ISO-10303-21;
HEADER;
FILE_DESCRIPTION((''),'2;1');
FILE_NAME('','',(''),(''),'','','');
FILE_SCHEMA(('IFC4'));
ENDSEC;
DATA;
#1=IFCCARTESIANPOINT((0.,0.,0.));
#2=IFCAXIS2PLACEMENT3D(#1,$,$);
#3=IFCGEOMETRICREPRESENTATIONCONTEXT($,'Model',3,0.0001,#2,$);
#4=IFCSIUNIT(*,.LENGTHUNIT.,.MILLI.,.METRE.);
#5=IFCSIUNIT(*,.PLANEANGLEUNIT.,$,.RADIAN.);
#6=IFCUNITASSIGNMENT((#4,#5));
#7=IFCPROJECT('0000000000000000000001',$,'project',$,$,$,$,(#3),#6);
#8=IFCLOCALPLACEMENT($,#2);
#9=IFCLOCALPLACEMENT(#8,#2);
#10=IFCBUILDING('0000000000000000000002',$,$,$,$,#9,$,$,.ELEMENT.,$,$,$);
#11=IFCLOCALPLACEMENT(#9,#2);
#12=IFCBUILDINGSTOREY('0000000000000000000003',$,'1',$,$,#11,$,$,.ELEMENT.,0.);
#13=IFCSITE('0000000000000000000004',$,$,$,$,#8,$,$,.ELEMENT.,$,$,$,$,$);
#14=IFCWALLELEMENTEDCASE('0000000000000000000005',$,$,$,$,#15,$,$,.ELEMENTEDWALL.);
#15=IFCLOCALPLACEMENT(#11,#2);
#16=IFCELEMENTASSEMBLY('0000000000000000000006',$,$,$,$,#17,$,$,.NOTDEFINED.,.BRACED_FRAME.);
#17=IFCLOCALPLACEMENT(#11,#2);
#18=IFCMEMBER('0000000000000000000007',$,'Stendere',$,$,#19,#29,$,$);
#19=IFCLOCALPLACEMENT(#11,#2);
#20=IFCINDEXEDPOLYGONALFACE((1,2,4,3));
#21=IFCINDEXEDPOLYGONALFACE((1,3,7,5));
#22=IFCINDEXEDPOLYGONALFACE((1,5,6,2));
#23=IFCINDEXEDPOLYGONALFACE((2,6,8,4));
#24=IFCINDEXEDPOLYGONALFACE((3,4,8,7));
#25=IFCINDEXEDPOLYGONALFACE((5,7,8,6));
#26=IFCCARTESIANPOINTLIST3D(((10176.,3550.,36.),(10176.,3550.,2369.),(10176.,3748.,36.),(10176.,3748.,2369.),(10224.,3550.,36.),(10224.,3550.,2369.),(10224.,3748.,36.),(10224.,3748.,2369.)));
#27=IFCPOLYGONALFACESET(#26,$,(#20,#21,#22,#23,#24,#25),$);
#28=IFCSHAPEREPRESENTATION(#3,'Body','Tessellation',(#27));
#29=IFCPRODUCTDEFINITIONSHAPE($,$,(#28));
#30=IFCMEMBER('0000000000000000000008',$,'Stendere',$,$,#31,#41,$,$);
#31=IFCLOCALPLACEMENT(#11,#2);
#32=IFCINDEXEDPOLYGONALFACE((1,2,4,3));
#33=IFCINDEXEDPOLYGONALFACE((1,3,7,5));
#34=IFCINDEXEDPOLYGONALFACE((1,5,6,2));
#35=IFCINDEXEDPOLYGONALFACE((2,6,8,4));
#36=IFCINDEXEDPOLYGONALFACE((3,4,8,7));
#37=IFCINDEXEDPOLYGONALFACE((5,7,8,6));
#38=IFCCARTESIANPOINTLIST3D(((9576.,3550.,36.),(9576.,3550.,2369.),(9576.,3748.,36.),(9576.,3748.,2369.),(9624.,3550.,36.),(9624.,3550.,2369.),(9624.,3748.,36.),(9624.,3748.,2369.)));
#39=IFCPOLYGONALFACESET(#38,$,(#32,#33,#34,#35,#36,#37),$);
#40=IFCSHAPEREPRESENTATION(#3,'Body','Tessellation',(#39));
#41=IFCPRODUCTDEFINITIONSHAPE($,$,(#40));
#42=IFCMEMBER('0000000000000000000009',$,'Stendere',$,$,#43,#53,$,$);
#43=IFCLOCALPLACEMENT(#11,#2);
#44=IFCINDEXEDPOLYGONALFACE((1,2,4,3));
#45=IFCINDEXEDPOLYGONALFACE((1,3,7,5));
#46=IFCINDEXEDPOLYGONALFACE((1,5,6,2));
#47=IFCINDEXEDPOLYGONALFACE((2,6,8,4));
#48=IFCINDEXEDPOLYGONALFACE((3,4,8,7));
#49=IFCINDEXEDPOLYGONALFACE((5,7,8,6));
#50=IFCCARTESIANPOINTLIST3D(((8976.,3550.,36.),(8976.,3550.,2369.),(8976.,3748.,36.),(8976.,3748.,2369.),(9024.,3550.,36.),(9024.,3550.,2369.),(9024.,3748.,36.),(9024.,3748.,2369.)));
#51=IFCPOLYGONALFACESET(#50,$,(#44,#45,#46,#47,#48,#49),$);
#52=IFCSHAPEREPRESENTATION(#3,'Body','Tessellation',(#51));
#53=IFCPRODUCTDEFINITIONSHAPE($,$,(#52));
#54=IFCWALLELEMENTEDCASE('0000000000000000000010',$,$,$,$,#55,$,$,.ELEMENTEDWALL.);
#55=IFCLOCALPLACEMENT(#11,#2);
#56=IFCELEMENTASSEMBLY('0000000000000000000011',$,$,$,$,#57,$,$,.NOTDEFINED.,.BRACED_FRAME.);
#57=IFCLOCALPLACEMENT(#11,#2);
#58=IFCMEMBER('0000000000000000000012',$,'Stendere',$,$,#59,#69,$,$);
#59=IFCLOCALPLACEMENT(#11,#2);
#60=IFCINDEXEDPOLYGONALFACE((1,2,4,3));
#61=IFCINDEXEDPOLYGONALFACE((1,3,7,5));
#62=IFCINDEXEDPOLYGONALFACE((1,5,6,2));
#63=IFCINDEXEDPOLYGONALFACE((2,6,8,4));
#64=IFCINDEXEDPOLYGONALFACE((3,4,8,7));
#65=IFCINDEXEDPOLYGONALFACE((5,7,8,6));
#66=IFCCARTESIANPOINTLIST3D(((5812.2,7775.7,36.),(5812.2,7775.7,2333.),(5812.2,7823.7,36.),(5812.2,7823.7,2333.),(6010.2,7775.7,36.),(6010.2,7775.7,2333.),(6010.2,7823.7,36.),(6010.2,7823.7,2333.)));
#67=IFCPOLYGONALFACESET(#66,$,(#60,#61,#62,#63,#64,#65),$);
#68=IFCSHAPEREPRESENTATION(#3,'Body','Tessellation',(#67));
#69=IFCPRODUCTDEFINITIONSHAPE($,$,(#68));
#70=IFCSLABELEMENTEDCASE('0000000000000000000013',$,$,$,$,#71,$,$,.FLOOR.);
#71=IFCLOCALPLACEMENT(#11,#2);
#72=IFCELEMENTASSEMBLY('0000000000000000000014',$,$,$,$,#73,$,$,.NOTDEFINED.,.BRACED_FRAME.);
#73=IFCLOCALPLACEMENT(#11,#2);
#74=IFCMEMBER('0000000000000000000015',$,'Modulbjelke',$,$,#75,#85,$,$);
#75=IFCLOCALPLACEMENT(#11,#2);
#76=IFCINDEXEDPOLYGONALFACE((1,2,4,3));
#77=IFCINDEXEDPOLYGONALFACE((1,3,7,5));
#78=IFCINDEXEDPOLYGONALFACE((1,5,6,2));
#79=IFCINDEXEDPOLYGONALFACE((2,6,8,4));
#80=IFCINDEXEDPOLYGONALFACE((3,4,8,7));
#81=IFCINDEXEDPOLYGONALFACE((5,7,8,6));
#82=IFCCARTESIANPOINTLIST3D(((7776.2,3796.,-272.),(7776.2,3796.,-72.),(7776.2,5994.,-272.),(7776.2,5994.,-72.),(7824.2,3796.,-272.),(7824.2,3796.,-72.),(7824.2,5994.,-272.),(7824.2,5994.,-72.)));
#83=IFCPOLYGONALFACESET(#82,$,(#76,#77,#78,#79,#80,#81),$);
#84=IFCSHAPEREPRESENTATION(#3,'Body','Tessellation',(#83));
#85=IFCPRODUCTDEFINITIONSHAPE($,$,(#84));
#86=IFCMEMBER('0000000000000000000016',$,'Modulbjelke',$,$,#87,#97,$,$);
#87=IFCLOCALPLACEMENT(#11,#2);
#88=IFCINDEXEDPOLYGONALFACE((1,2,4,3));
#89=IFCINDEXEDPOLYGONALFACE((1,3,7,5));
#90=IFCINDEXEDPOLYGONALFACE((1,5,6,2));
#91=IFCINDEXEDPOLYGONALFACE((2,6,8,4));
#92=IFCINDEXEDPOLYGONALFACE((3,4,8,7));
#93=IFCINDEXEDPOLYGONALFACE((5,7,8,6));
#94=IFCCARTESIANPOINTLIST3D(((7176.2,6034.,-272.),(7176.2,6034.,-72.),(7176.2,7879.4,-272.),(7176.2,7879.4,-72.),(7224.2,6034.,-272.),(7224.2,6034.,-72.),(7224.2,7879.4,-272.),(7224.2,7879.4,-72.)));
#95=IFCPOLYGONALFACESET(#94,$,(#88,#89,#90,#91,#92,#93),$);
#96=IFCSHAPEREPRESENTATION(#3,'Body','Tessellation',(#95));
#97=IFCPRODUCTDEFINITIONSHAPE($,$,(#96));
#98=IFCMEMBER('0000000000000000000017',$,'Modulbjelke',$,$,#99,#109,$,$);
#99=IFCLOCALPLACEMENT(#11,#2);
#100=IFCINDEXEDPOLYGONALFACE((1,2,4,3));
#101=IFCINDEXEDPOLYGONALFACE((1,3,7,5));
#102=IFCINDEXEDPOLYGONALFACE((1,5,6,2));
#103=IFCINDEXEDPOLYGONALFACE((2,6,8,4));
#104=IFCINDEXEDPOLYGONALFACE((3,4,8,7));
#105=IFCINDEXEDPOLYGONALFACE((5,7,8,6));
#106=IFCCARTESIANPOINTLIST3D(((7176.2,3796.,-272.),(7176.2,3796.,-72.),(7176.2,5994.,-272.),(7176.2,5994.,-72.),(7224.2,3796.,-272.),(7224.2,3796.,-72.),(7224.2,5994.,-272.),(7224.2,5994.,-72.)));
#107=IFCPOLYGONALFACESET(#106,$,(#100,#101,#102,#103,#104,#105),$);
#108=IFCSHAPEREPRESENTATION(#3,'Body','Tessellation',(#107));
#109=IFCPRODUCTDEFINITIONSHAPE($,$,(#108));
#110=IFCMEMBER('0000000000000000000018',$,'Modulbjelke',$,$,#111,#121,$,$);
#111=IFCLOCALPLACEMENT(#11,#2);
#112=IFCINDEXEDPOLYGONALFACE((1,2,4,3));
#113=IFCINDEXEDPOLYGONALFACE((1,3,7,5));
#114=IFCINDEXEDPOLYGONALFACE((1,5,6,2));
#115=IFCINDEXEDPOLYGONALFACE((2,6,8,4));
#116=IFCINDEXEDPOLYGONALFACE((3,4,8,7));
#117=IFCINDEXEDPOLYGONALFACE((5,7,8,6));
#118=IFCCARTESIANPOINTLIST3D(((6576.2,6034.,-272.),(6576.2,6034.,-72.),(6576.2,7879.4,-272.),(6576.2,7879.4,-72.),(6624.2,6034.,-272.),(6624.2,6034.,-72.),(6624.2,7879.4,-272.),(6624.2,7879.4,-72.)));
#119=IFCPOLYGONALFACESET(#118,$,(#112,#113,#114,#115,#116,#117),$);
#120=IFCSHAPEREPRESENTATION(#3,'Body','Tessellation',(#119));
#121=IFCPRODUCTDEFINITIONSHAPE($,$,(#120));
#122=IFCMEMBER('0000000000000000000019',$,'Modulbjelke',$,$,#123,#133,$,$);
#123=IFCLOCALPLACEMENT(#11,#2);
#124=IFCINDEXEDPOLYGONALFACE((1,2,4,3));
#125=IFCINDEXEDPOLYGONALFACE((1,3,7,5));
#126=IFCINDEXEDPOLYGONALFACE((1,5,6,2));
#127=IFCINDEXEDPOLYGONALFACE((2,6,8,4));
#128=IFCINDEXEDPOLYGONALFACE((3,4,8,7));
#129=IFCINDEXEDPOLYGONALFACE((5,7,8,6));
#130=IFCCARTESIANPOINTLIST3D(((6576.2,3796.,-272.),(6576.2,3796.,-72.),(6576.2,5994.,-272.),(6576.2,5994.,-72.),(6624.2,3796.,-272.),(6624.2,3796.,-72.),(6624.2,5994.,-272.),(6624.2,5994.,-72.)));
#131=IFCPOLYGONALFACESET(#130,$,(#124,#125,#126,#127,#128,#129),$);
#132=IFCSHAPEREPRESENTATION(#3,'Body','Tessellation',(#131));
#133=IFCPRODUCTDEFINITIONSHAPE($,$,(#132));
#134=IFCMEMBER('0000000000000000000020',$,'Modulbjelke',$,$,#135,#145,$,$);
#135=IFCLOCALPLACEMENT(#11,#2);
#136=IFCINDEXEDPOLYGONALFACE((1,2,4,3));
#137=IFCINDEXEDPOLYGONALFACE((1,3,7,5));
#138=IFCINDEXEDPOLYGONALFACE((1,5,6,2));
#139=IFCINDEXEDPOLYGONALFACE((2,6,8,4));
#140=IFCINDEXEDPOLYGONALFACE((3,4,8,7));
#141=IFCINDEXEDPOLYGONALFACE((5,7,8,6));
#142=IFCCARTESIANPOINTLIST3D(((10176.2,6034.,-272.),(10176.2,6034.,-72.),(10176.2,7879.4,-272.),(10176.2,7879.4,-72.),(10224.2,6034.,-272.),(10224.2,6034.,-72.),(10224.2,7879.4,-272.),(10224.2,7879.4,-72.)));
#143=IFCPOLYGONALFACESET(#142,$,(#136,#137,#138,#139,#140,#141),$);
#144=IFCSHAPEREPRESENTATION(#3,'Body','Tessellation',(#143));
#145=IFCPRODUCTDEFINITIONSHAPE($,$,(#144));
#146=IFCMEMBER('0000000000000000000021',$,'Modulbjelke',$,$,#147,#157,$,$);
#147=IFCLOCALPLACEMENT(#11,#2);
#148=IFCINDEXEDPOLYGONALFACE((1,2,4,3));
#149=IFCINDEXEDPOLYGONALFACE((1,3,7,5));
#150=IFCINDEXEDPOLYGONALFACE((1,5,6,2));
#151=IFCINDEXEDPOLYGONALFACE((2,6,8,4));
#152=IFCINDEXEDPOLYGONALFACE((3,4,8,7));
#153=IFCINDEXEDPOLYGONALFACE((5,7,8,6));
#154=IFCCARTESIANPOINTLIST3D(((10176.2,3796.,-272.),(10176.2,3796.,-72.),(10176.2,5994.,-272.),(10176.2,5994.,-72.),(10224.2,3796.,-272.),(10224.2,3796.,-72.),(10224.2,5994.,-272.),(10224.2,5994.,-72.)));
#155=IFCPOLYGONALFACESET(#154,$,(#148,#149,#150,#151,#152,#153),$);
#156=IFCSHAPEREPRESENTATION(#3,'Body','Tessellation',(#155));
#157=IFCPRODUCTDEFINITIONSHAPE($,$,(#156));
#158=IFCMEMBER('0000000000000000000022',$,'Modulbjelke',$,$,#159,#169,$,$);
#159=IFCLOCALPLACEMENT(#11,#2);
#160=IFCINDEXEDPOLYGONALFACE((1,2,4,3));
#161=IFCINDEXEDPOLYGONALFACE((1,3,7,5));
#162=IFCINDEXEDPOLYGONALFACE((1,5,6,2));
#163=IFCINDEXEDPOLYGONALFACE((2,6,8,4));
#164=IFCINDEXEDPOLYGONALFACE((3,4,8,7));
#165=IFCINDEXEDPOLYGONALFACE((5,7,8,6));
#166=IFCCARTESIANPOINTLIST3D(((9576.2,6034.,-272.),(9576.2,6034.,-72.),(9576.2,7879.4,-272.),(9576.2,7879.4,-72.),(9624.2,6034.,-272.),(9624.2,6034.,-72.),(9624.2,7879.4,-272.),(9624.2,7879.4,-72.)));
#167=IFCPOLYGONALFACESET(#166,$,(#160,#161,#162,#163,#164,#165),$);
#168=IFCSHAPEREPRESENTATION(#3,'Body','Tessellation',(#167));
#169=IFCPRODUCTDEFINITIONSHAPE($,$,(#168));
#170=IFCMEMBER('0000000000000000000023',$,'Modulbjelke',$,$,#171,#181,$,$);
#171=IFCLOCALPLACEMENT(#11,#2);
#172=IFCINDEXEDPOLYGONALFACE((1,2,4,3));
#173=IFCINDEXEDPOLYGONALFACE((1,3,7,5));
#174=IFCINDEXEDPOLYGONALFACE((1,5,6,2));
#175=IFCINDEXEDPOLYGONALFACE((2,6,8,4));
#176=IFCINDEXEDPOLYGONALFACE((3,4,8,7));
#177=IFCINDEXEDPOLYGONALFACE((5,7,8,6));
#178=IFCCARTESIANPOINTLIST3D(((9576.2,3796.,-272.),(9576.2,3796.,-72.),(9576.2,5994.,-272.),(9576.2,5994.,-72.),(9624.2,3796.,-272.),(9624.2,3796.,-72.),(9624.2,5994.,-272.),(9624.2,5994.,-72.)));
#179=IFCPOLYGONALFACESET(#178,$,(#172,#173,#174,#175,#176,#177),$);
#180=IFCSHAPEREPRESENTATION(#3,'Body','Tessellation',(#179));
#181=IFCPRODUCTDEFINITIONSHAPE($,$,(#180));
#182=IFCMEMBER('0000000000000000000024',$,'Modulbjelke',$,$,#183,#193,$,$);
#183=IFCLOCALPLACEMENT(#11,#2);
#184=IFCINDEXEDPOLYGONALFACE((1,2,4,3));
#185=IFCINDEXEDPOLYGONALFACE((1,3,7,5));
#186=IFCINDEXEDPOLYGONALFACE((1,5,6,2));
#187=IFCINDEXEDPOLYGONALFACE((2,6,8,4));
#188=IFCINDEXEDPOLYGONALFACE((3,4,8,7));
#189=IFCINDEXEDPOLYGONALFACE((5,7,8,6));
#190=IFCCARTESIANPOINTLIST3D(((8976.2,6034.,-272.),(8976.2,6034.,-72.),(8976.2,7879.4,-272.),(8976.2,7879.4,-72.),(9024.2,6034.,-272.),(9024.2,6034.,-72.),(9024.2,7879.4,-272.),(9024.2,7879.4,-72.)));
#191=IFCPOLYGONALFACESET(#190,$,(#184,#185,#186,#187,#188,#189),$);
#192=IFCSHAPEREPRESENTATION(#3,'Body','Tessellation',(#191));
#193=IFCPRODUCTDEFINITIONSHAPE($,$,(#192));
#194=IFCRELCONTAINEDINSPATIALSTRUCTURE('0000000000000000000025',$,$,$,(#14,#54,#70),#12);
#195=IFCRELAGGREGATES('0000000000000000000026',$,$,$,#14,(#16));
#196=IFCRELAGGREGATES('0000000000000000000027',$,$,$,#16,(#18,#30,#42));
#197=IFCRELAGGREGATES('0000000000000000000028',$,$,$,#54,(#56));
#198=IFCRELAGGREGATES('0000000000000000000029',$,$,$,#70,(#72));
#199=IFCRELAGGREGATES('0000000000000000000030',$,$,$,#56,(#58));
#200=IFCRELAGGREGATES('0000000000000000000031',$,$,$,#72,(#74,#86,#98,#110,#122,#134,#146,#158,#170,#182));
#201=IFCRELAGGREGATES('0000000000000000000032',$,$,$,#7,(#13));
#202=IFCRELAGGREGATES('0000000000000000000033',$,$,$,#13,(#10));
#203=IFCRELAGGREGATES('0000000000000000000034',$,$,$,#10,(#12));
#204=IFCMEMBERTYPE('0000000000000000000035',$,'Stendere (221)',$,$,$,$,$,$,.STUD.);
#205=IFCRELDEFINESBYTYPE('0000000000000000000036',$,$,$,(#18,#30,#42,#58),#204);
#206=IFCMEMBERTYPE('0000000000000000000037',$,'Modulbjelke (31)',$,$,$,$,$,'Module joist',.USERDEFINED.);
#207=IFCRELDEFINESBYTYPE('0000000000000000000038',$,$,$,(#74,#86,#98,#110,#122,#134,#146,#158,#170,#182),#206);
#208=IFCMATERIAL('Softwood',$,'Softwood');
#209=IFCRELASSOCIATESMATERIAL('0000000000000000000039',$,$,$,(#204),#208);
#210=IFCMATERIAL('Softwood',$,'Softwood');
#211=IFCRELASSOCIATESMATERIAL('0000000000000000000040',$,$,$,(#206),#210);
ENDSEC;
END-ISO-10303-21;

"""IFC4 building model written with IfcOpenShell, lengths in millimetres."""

from ifc_helpers import new_model, si_unit, frame, origin, place, context, project, spatial, rectangle, extrude, clip, halfspace, material, material_profile, profile_set, type_object, element, aggregate, save


model = new_model("IFC4")

# Units and contexts
model_context = context("Model", 3, precision=0.0001, world=origin())
ifc_project = project(units=[si_unit("LENGTHUNIT", "METRE", prefix="MILLI"), si_unit("PLANEANGLEUNIT", "RADIAN")], contexts=[model_context])

# Site, building, storey
site_placement = place(None, origin())
site = spatial("IfcSite", under=ifc_project, at=site_placement, CompositionType="ELEMENT")
building_placement = place(site_placement, origin())
building = spatial("IfcBuilding", under=site, at=building_placement, CompositionType="ELEMENT")
storey_placement = place(building_placement, origin())
storey = spatial("IfcBuildingStorey", under=building, at=storey_placement, Name="1", CompositionType="ELEMENT", Elevation=0.0)

# Wall, element assembly, members
wall_1_placement = place(storey_placement, frame((6576.0, 3748.0, 0.0), z_axis=(0.0, -1.0, 0.0)))
wall_1 = element("IfcWallElementedCase", 1, at=wall_1_placement, inside=storey, PredefinedType="ELEMENTEDWALL")
assembly_1_placement = place(wall_1_placement, origin())
assembly_1 = element("IfcElementAssembly", 2, at=assembly_1_placement, AssemblyPlace="NOTDEFINED", PredefinedType="BRACED_FRAME")
aggregate(wall_1, [assembly_1])
ifc_material_1 = material(Name="Softwood", Category="Softwood")
ifc_material_profile_1 = material_profile(ifc_material_1, rectangle(XDim=48.0, YDim=198.0), Name="Stendere (221)")
ifc_profile_set_1 = profile_set([ifc_material_profile_1])
member_type_1 = type_object("IfcMemberType", Name="Stendere (221)", PredefinedType="STUD", material=ifc_profile_set_1)
member_1_placement = place(assembly_1_placement, frame((3624.0, 36.0, 0.0), z_axis=(0.0, 1.0, 0.0), x_axis=(-1.0, 0.0, 0.0)))
member_1 = element("IfcMember", 3, at=member_1_placement, type_object=member_type_1, Name="Stendere", context=model_context, shape_type="SweptSolid", body=[
    extrude(rectangle(XDim=48.0, YDim=198.0), frame((0.0, 99.0, 0.0)), (0.0, 0.0, 1.0), 2333.0),
])
member_2_placement = place(assembly_1_placement, frame((3024.0, 36.0, 0.0), z_axis=(0.0, 1.0, 0.0), x_axis=(-1.0, 0.0, 0.0)))
member_2 = element("IfcMember", 4, at=member_2_placement, type_object=member_type_1, Name="Stendere", context=model_context, shape_type="SweptSolid", body=[
    extrude(rectangle(XDim=48.0, YDim=198.0), frame((0.0, 99.0, 0.0)), (0.0, 0.0, 1.0), 2333.0),
])
member_3_placement = place(assembly_1_placement, frame((2424.0, 36.0, 0.0), z_axis=(0.0, 1.0, 0.0), x_axis=(-1.0, 0.0, 0.0)))
member_3 = element("IfcMember", 5, at=member_3_placement, type_object=member_type_1, Name="Stendere", context=model_context, shape_type="Clipping", body=[
    clip(extrude(rectangle(XDim=48.0, YDim=198.0), frame((0.0, 99.0, 0.0)), (0.0, 0.0, 1.0), 2333.0), halfspace(frame((0.0, 99.0, 0.0)), True)),
])
aggregate(assembly_1, [member_1, member_2, member_3])

# Wall, element assembly, member
wall_2_placement = place(storey_placement, frame((6010.2, 8138.7, 0.0), z_axis=(-1.0, 0.0, 0.0), x_axis=(0.0, -1.0, 0.0)))
wall_2 = element("IfcWallElementedCase", 6, at=wall_2_placement, inside=storey, PredefinedType="ELEMENTEDWALL")
assembly_2_placement = place(wall_2_placement, origin())
assembly_2 = element("IfcElementAssembly", 7, at=assembly_2_placement, AssemblyPlace="NOTDEFINED", PredefinedType="BRACED_FRAME")
aggregate(wall_2, [assembly_2])
member_4_placement = place(assembly_2_placement, frame((339.0, 36.0, 0.0), z_axis=(0.0, 1.0, 0.0), x_axis=(-1.0, 0.0, 0.0)))
member_4 = element("IfcMember", 8, at=member_4_placement, type_object=member_type_1, Name="Stendere", context=model_context, shape_type="SweptSolid", body=[
    extrude(rectangle(XDim=48.0, YDim=198.0), frame((0.0, 99.0, 0.0)), (0.0, 0.0, 1.0), 2297.0),
])

# Slab, element assembly, members
slab_placement = place(storey_placement, origin())
slab = element("IfcSlabElementedCase", 9, at=slab_placement, inside=storey, PredefinedType="FLOOR")
assembly_3_placement = place(slab_placement, frame((0.0, 0.0, -225.0)))
assembly_3 = element("IfcElementAssembly", 10, at=assembly_3_placement, AssemblyPlace="NOTDEFINED", PredefinedType="BRACED_FRAME")
aggregate(slab, [assembly_3])
ifc_material_2 = material(Name="Softwood", Category="Softwood")
ifc_material_profile_2 = material_profile(ifc_material_2, rectangle(XDim=48.0, YDim=200.0), Name="Modulbjelke (31)")
ifc_profile_set_2 = profile_set([ifc_material_profile_2])
member_type_2 = type_object("IfcMemberType", Name="Modulbjelke (31)", ElementType="Module joist", PredefinedType="USERDEFINED", material=ifc_profile_set_2)
member_5_placement = place(assembly_3_placement, frame((7800.2, 3796.0, -47.0), z_axis=(0.000002, 1.0, 0.0), x_axis=(-1.0, 0.000002, 0.0)))
member_5 = element("IfcMember", 11, at=member_5_placement, type_object=member_type_2, Name="Modulbjelke", context=model_context, shape_type="Clipping", body=[
    clip(clip(extrude(rectangle(XDim=48.0, YDim=200.0), frame((0.0, 100.0, 0.0)), (0.0, 0.0, 1.0), 2198.0), halfspace(frame((0.0, 100.0, 0.0)), True)), halfspace(frame((0.0, 100.0, 2198.0)), False)),
])
member_6_placement = place(assembly_3_placement, frame((7200.2, 6034.0, -47.0), z_axis=(-0.000003, 1.0, 0.0), x_axis=(-1.0, -0.000003, 0.0)))
member_6 = element("IfcMember", 12, at=member_6_placement, type_object=member_type_2, Name="Modulbjelke", context=model_context, shape_type="Clipping", body=[
    clip(clip(extrude(rectangle(XDim=48.0, YDim=200.0), frame((0.0, 100.0, 0.0)), (0.0, 0.0, 1.0), 1845.4), halfspace(frame((0.0, 100.0, 0.0)), True)), halfspace(frame((0.0, 100.0, 1845.4)), False)),
])
member_7_placement = place(assembly_3_placement, frame((7200.2, 3796.0, -47.0), z_axis=(0.000002, 1.0, 0.0), x_axis=(-1.0, 0.000002, 0.0)))
member_7 = element("IfcMember", 13, at=member_7_placement, type_object=member_type_2, Name="Modulbjelke", context=model_context, shape_type="Clipping", body=[
    clip(clip(extrude(rectangle(XDim=48.0, YDim=200.0), frame((0.0, 100.0, 0.0)), (0.0, 0.0, 1.0), 2198.0), halfspace(frame((0.0, 100.0, 0.0)), True)), halfspace(frame((0.0, 100.0, 2198.0)), False)),
])
member_8_placement = place(assembly_3_placement, frame((6600.2, 6034.0, -47.0), z_axis=(-0.000003, 1.0, 0.0), x_axis=(-1.0, -0.000003, 0.0)))
member_8 = element("IfcMember", 14, at=member_8_placement, type_object=member_type_2, Name="Modulbjelke", context=model_context, shape_type="Clipping", body=[
    clip(clip(extrude(rectangle(XDim=48.0, YDim=200.0), frame((0.0, 100.0, 0.0)), (0.0, 0.0, 1.0), 1845.4), halfspace(frame((0.0, 100.0, 0.0)), True)), halfspace(frame((0.0, 100.0, 1845.4)), False)),
])
member_9_placement = place(assembly_3_placement, frame((6600.2, 3796.0, -47.0), z_axis=(0.000002, 1.0, 0.0), x_axis=(-1.0, 0.000002, 0.0)))
member_9 = element("IfcMember", 15, at=member_9_placement, type_object=member_type_2, Name="Modulbjelke", context=model_context, shape_type="Clipping", body=[
    clip(clip(extrude(rectangle(XDim=48.0, YDim=200.0), frame((0.0, 100.0, 0.0)), (0.0, 0.0, 1.0), 2198.0), halfspace(frame((0.0, 100.0, 0.0)), True)), halfspace(frame((0.0, 100.0, 2198.0)), False)),
])
member_10_placement = place(assembly_3_placement, frame((10200.2, 6034.0, -47.0), z_axis=(0.000002, 1.0, 0.0), x_axis=(-1.0, 0.000002, 0.0)))
member_10 = element("IfcMember", 16, at=member_10_placement, type_object=member_type_2, Name="Modulbjelke", context=model_context, shape_type="Clipping", body=[
    clip(clip(extrude(rectangle(XDim=48.0, YDim=200.0), frame((0.0, 100.0, 0.0)), (0.0, 0.0, 1.0), 1845.4), halfspace(frame((0.0, 100.0, 0.0)), True)), halfspace(frame((0.0, 100.0, 1845.4)), False)),
])
member_11_placement = place(assembly_3_placement, frame((10200.2, 3796.0, -47.0), z_axis=(-0.000002, 1.0, 0.0), x_axis=(-1.0, -0.000002, 0.0)))
member_11 = element("IfcMember", 17, at=member_11_placement, type_object=member_type_2, Name="Modulbjelke", context=model_context, shape_type="Clipping", body=[
    clip(clip(extrude(rectangle(XDim=48.0, YDim=200.0), frame((0.0, 100.0, 0.0)), (0.0, 0.0, 1.0), 2198.0), halfspace(frame((0.0, 100.0, 0.0)), True)), halfspace(frame((0.0, 100.0, 2198.0)), False)),
])
member_12_placement = place(assembly_3_placement, frame((9600.2, 6034.0, -47.0), z_axis=(0.000002, 1.0, 0.0), x_axis=(-1.0, 0.000002, 0.0)))
member_12 = element("IfcMember", 18, at=member_12_placement, type_object=member_type_2, Name="Modulbjelke", context=model_context, shape_type="Clipping", body=[
    clip(clip(extrude(rectangle(XDim=48.0, YDim=200.0), frame((0.0, 100.0, 0.0)), (0.0, 0.0, 1.0), 1845.4), halfspace(frame((0.0, 100.0, 0.0)), True)), halfspace(frame((0.0, 100.0, 1845.4)), False)),
])
member_13_placement = place(assembly_3_placement, frame((9600.2, 3796.0, -47.0), z_axis=(-0.000002, 1.0, 0.0), x_axis=(-1.0, -0.000002, 0.0)))
member_13 = element("IfcMember", 19, at=member_13_placement, type_object=member_type_2, Name="Modulbjelke", context=model_context, shape_type="Clipping", body=[
    clip(clip(extrude(rectangle(XDim=48.0, YDim=200.0), frame((0.0, 100.0, 0.0)), (0.0, 0.0, 1.0), 2198.0), halfspace(frame((0.0, 100.0, 0.0)), True)), halfspace(frame((0.0, 100.0, 2198.0)), False)),
])
member_14_placement = place(assembly_3_placement, frame((9000.2, 6034.0, -47.0), z_axis=(0.000002, 1.0, 0.0), x_axis=(-1.0, 0.000002, 0.0)))
member_14 = element("IfcMember", 20, at=member_14_placement, type_object=member_type_2, Name="Modulbjelke", context=model_context, shape_type="Clipping", body=[
    clip(clip(extrude(rectangle(XDim=48.0, YDim=200.0), frame((0.0, 100.0, 0.0)), (0.0, 0.0, 1.0), 1845.4), halfspace(frame((0.0, 100.0, 0.0)), True)), halfspace(frame((0.0, 100.0, 1845.4)), False)),
])

aggregate(assembly_2, [member_4])

aggregate(assembly_3, [member_5, member_6, member_7, member_8, member_9, member_10, member_11, member_12, member_13, member_14])

save(model, "model.ifc")
